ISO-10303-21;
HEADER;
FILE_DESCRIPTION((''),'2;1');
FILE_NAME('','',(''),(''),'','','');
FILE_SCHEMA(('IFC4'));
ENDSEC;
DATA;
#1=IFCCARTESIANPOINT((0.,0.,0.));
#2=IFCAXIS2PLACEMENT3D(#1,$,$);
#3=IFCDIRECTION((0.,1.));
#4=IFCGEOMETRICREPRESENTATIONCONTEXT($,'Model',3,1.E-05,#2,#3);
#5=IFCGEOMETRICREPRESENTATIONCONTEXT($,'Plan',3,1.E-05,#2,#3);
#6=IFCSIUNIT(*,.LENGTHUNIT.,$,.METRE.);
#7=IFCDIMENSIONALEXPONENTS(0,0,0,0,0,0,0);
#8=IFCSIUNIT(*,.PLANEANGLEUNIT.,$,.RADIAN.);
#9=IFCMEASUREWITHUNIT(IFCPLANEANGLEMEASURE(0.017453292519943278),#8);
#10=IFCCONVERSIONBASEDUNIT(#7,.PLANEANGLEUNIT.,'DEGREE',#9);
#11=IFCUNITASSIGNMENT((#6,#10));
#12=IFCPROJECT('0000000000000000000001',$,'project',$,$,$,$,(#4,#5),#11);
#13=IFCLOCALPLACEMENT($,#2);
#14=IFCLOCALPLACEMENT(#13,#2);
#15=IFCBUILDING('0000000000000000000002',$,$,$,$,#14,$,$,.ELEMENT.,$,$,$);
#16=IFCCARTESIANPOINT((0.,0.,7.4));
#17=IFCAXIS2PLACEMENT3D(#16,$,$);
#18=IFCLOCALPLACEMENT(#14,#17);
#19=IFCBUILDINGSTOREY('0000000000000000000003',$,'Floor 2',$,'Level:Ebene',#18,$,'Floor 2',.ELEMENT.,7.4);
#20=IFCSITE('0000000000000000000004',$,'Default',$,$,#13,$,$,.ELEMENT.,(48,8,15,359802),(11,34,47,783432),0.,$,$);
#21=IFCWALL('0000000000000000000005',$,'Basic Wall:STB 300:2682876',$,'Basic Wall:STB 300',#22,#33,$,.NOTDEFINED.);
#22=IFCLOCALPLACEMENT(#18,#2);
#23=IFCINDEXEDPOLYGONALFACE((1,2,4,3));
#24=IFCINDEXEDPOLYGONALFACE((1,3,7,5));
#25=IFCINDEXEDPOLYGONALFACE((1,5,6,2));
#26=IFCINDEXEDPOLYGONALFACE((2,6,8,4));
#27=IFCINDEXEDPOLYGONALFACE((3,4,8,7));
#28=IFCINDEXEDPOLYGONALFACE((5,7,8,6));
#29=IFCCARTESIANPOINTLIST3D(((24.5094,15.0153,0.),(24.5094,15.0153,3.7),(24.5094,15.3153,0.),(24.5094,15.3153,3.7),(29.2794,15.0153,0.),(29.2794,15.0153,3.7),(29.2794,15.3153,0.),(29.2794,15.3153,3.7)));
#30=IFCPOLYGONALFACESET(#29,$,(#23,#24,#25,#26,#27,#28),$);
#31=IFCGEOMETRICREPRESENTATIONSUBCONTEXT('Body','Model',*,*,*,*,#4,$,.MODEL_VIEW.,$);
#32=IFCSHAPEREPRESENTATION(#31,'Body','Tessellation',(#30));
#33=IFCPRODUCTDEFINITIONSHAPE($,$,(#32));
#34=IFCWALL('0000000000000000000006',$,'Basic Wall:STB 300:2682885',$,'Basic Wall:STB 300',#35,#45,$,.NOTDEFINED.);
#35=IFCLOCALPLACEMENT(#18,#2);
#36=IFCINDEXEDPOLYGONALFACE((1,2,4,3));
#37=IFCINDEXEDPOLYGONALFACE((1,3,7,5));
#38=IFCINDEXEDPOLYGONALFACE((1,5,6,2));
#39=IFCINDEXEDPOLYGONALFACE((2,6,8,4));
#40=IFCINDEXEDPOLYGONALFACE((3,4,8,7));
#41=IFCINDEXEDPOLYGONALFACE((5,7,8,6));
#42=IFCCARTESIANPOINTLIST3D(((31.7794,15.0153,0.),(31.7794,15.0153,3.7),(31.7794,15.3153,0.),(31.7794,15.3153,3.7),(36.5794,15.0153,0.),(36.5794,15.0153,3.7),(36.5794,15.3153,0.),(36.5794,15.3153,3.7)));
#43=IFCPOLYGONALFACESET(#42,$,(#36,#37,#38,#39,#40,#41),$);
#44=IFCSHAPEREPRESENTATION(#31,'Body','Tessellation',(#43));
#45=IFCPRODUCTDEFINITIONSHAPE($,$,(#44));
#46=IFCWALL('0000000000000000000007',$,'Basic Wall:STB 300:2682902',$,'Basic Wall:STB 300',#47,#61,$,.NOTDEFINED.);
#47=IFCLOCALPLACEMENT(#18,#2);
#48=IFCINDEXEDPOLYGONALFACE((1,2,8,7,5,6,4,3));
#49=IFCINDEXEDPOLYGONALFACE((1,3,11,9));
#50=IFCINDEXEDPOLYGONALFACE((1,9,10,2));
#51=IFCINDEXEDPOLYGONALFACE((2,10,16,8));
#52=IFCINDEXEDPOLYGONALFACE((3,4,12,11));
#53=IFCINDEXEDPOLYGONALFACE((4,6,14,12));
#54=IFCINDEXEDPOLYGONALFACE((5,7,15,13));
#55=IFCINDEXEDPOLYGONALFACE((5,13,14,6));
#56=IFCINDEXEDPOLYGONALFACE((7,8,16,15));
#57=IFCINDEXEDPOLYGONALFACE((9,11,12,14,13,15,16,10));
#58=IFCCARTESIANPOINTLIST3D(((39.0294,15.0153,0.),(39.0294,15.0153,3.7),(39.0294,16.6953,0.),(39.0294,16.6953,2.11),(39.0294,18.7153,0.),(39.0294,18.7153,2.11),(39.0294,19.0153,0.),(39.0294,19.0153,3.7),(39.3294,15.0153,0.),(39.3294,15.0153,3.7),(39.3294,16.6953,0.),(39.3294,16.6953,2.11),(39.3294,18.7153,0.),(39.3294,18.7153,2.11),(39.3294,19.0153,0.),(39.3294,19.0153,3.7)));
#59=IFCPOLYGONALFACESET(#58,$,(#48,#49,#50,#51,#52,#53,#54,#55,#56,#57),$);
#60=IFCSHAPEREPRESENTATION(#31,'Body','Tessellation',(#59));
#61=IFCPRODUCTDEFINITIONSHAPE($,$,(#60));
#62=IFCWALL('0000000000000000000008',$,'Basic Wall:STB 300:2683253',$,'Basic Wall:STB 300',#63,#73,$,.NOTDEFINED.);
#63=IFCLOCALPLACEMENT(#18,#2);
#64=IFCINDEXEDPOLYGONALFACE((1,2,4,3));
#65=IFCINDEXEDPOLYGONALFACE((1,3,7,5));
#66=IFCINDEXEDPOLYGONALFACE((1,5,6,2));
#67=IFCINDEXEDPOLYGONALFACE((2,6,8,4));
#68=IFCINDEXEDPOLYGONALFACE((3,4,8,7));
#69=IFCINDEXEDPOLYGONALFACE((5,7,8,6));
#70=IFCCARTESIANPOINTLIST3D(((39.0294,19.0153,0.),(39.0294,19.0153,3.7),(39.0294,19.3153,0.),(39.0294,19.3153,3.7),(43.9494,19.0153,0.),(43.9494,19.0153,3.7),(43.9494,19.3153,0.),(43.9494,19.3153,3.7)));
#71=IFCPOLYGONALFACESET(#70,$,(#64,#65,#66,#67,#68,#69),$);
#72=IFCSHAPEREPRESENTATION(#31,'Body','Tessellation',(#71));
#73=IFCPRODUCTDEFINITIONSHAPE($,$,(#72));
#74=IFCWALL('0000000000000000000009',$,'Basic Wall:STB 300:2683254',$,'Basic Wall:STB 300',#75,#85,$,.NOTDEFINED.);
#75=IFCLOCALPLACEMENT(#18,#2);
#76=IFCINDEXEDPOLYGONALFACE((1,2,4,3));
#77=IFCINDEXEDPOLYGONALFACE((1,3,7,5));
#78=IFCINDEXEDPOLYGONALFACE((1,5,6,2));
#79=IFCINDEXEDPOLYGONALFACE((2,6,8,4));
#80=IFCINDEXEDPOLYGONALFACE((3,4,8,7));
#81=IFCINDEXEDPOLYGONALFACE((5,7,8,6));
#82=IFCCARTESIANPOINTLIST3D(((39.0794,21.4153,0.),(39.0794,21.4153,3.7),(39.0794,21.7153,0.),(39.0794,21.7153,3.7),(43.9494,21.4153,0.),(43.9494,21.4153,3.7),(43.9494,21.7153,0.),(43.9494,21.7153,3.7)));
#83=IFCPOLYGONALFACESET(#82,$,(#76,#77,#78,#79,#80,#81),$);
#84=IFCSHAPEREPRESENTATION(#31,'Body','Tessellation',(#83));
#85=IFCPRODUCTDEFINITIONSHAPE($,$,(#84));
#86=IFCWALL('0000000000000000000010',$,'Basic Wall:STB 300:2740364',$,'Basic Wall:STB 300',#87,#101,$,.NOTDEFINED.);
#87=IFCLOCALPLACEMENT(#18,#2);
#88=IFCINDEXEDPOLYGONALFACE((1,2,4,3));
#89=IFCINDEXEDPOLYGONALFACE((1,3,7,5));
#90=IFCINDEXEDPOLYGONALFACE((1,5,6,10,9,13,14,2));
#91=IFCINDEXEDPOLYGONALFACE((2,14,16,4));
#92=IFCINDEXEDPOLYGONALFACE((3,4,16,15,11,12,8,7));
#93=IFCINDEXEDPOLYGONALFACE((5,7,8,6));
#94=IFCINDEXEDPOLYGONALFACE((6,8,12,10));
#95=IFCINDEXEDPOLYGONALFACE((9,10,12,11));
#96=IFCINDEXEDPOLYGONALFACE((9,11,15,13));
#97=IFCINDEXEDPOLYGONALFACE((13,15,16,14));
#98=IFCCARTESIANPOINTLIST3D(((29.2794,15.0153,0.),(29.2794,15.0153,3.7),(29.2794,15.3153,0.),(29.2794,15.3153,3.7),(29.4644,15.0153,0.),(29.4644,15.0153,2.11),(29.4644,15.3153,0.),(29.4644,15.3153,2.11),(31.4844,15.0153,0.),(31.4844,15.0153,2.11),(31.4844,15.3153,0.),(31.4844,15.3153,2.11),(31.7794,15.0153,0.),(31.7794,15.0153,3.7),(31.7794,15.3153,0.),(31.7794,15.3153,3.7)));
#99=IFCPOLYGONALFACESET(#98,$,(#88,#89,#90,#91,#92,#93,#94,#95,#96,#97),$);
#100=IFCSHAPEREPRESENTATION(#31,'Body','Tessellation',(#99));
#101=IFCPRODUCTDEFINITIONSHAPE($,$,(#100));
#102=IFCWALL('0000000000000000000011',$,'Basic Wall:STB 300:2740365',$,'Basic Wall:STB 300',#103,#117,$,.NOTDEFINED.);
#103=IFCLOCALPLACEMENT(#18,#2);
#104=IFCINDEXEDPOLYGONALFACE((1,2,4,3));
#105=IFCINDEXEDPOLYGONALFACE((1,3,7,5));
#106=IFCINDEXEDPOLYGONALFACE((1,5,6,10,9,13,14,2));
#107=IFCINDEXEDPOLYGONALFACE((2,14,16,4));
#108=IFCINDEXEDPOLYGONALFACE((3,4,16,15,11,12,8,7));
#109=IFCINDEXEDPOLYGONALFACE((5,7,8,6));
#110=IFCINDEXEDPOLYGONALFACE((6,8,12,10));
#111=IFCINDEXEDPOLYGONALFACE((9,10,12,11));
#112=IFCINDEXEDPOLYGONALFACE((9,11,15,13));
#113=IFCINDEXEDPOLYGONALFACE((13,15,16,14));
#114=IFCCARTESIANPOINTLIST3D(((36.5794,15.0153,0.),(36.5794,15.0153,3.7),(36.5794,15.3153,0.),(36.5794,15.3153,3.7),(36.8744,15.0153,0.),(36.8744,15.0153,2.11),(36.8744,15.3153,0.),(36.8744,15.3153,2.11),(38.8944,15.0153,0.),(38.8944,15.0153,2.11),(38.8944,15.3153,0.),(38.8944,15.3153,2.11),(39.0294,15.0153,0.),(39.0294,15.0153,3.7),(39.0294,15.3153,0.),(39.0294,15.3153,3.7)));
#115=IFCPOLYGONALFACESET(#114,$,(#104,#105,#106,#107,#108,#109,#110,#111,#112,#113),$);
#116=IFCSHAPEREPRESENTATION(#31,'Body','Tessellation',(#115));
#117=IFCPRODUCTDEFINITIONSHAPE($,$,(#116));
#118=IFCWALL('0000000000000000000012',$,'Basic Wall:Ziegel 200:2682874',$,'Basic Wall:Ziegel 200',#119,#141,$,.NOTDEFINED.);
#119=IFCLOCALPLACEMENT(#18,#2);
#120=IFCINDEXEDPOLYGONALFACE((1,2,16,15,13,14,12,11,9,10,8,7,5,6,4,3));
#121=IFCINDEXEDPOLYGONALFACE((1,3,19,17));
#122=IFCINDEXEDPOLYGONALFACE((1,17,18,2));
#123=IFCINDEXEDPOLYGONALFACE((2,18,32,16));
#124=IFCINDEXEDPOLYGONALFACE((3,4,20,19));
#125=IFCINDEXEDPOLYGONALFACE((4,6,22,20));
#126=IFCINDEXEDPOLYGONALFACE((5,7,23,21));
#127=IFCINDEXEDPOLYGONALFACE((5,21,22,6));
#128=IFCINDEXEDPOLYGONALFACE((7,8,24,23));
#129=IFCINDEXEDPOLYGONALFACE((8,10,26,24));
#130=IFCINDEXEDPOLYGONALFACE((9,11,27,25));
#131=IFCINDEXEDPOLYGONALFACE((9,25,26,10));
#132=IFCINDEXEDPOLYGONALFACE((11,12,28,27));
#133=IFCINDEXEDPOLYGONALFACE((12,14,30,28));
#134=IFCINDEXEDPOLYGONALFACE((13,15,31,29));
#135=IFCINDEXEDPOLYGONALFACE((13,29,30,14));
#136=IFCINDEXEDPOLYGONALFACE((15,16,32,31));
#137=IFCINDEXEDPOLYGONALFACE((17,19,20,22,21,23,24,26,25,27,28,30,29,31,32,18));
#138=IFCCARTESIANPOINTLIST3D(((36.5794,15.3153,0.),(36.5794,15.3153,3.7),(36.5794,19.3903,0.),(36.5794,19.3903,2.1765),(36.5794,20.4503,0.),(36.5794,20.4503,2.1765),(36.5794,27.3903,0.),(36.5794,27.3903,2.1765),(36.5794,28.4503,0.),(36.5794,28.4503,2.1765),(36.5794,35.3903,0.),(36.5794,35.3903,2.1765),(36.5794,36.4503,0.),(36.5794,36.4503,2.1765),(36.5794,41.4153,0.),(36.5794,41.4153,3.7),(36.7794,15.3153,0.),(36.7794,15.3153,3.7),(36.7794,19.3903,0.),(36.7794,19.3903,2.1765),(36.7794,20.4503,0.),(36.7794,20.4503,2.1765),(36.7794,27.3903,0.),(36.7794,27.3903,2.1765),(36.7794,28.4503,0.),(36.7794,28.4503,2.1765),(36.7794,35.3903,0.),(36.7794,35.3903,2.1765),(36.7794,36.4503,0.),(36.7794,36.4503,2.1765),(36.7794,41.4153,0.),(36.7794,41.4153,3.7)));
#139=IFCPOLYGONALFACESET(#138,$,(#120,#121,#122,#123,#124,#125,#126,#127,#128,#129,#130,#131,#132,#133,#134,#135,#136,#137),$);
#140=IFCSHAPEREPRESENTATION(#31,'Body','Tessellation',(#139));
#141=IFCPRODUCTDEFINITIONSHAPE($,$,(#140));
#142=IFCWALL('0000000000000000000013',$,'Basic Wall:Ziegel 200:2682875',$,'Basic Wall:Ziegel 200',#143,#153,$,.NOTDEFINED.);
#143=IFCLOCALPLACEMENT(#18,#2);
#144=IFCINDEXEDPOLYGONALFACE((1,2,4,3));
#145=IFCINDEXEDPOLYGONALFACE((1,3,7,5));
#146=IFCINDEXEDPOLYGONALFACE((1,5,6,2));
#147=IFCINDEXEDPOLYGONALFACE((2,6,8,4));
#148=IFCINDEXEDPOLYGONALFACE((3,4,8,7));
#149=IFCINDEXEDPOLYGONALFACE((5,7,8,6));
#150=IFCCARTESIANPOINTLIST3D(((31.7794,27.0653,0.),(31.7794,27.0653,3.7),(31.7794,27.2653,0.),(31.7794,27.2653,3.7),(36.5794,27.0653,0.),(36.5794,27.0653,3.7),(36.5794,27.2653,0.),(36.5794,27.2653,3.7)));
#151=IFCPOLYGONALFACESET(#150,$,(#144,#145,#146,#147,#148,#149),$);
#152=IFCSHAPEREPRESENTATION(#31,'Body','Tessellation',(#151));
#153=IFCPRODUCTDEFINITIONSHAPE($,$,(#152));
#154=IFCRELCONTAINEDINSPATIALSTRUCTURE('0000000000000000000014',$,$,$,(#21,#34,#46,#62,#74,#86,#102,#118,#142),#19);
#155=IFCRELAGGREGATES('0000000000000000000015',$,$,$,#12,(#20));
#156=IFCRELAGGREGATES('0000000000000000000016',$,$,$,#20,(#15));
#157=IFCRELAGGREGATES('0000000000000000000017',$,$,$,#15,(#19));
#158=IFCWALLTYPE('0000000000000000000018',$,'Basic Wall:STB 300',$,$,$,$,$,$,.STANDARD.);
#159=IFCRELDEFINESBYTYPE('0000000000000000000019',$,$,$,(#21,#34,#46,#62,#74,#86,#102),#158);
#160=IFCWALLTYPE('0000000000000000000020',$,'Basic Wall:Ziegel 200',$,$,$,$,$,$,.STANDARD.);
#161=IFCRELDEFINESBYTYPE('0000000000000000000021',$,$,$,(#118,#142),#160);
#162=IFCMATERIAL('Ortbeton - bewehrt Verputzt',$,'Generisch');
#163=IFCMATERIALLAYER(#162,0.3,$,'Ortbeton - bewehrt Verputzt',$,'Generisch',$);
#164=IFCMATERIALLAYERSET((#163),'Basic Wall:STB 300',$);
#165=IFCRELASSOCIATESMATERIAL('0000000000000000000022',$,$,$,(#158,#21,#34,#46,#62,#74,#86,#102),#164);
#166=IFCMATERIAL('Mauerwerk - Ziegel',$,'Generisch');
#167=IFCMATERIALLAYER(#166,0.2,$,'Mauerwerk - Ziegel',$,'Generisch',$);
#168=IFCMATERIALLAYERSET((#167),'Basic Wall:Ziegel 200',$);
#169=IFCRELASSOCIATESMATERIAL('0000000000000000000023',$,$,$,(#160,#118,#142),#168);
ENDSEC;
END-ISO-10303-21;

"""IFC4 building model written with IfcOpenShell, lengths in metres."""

from ifc_helpers import new_model, entity, si_unit, converted_unit, direction, frame, frame_2d, origin, place, context, subcontext, project, spatial, rectangle, extrude, material, layer, layer_set, layer_usage, type_object, element, save


model = new_model("IFC4")

# Units and contexts
model_context = context("Model", 3, precision=1e-05, world=origin(), true_north=direction((0.0, 1.0)))
plan_context = context("Plan", 3, precision=1e-05, world=origin(), true_north=direction((0.0, 1.0)))
body_context = subcontext(model_context, "Body", "Model", "MODEL_VIEW")
ifc_project = project(units=[si_unit("LENGTHUNIT", "METRE"), converted_unit("PLANEANGLEUNIT", "DEGREE", entity("IfcPlaneAngleMeasure", 0.017453292519943278), si_unit("PLANEANGLEUNIT", "RADIAN"), dimensions=[0, 0, 0, 0, 0, 0, 0])], contexts=[model_context, plan_context])

# Site, building, storey
site_placement = place(None, origin())
site = spatial("IfcSite", under=ifc_project, at=site_placement, Name="Default", CompositionType="ELEMENT", RefLatitude=(48, 8, 15, 359802), RefLongitude=(11, 34, 47, 783432), RefElevation=0.0)
building_placement = place(site_placement, origin())
building = spatial("IfcBuilding", under=site, at=building_placement, CompositionType="ELEMENT")
storey_placement = place(building_placement, frame((0.0, 0.0, 7.4)))
storey = spatial("IfcBuildingStorey", under=building, at=storey_placement, Name="Floor 2", ObjectType="Level:Ebene", LongName="Floor 2", CompositionType="ELEMENT", Elevation=7.4)

# Walls
ifc_material_1 = material(Name="Ortbeton - bewehrt Verputzt", Category="Generisch")
ifc_layer_1 = layer(ifc_material_1, 0.3, Name="Ortbeton - bewehrt Verputzt", Category="Generisch")
ifc_layer_set_1 = layer_set([ifc_layer_1], Name="Basic Wall:STB 300")
ifc_layer_usage_1 = layer_usage(ifc_layer_set_1, "AXIS2", "NEGATIVE", 0.15)
wall_type_1 = type_object("IfcWallType", Name="Basic Wall:STB 300", PredefinedType="STANDARD", material=ifc_layer_set_1)
wall_1_placement = place(storey_placement, frame((24.5094, 15.1653, 0.0)))
element("IfcWall", 1, at=wall_1_placement, inside=storey, type_object=wall_type_1, material=ifc_layer_usage_1, Name="Basic Wall:STB 300:2682876", ObjectType="Basic Wall:STB 300", PredefinedType="NOTDEFINED", context=body_context, shape_type="SweptSolid", body=[
    extrude(rectangle(XDim=4.77, YDim=0.3, at=frame_2d((2.385, 0.0), x_axis=(-1.0, 0.0))), origin(), (0.0, 0.0, 1.0), 3.7),
])
wall_2_placement = place(storey_placement, frame((31.7794, 15.1653, 0.0)))
element("IfcWall", 2, at=wall_2_placement, inside=storey, type_object=wall_type_1, material=ifc_layer_usage_1, Name="Basic Wall:STB 300:2682885", ObjectType="Basic Wall:STB 300", PredefinedType="NOTDEFINED", context=body_context, shape_type="SweptSolid", body=[
    extrude(rectangle(XDim=4.8, YDim=0.3, at=frame_2d((2.4, 0.0), x_axis=(-1.0, 0.0))), origin(), (0.0, 0.0, 1.0), 3.7),
])

# Wall, opening
wall_3_placement = place(storey_placement, frame((39.1794, 19.0153, 0.0), z_axis=(0.0, 0.0, 1.0), x_axis=(0.0, -1.0, 0.0)))
wall_3 = element("IfcWall", 3, at=wall_3_placement, inside=storey, type_object=wall_type_1, material=ifc_layer_usage_1, Name="Basic Wall:STB 300:2682902", ObjectType="Basic Wall:STB 300", PredefinedType="NOTDEFINED", context=body_context, shape_type="SweptSolid", body=[
    extrude(rectangle(XDim=4.0, YDim=0.3, at=frame_2d((2.0, 0.0), x_axis=(1.0, 0.0))), origin(), (0.0, 0.0, 1.0), 3.7),
])
opening_1_placement = place(wall_3_placement, frame((2.32, 0.15, 0.0)))
element("IfcOpeningElement", 4, at=opening_1_placement, cuts=wall_3, PredefinedType="OPENING", context=body_context, shape_type="SweptSolid", body=[
    extrude(rectangle(XDim=2.11, YDim=2.02, at=frame_2d((1.055, 1.01), x_axis=(1.0, 0.0))), frame((0.0, 0.0, 0.0), z_axis=(0.0, -1.0, 0.0), x_axis=(0.0, 0.0, 1.0)), (0.0, 0.0, 1.0), 0.3),
])

# Walls
wall_4_placement = place(storey_placement, frame((43.9494, 19.1653, 0.0), z_axis=(0.0, 0.0, 1.0), x_axis=(-1.0, 0.0, 0.0)))
element("IfcWall", 5, at=wall_4_placement, inside=storey, type_object=wall_type_1, material=ifc_layer_usage_1, Name="Basic Wall:STB 300:2683253", ObjectType="Basic Wall:STB 300", PredefinedType="NOTDEFINED", context=body_context, shape_type="SweptSolid", body=[
    extrude(rectangle(XDim=4.92, YDim=0.3, at=frame_2d((2.46, 0.0), x_axis=(-1.0, 0.0))), origin(), (0.0, 0.0, 1.0), 3.7),
])
wall_5_placement = place(storey_placement, frame((39.0794, 21.5653, 0.0)))
element("IfcWall", 6, at=wall_5_placement, inside=storey, type_object=wall_type_1, material=ifc_layer_usage_1, Name="Basic Wall:STB 300:2683254", ObjectType="Basic Wall:STB 300", PredefinedType="NOTDEFINED", context=body_context, shape_type="SweptSolid", body=[
    extrude(rectangle(XDim=4.87, YDim=0.3, at=frame_2d((2.435, 0.0), x_axis=(-1.0, 0.0))), origin(), (0.0, 0.0, 1.0), 3.7),
])

# Walls, openings
wall_6_placement = place(storey_placement, frame((29.2794, 15.1653, 0.0)))
wall_6 = element("IfcWall", 7, at=wall_6_placement, inside=storey, type_object=wall_type_1, material=ifc_layer_usage_1, Name="Basic Wall:STB 300:2740364", ObjectType="Basic Wall:STB 300", PredefinedType="NOTDEFINED", context=body_context, shape_type="SweptSolid", body=[
    extrude(rectangle(XDim=2.5, YDim=0.3, at=frame_2d((1.25, 0.0), x_axis=(-1.0, 0.0))), origin(), (0.0, 0.0, 1.0), 3.7),
])
opening_2_placement = place(wall_6_placement, frame((0.185, -0.15, 0.0)))
element("IfcOpeningElement", 8, at=opening_2_placement, cuts=wall_6, PredefinedType="OPENING", context=body_context, shape_type="SweptSolid", body=[
    extrude(rectangle(XDim=2.11, YDim=2.02, at=frame_2d((1.055, 1.01), x_axis=(1.0, 0.0))), frame((0.0, 0.0, 0.0), z_axis=(0.0, 1.0, 0.0), x_axis=(0.0, 0.0, 1.0)), (0.0, 0.0, 1.0), 0.3),
])
wall_7_placement = place(storey_placement, frame((36.5794, 15.1653, 0.0)))
wall_7 = element("IfcWall", 9, at=wall_7_placement, inside=storey, type_object=wall_type_1, material=ifc_layer_usage_1, Name="Basic Wall:STB 300:2740365", ObjectType="Basic Wall:STB 300", PredefinedType="NOTDEFINED", context=body_context, shape_type="SweptSolid", body=[
    extrude(rectangle(XDim=2.45, YDim=0.3, at=frame_2d((1.225, 0.0), x_axis=(-1.0, 0.0))), origin(), (0.0, 0.0, 1.0), 3.7),
])
opening_3_placement = place(wall_7_placement, frame((0.295, -0.15, 0.0)))
element("IfcOpeningElement", 10, at=opening_3_placement, cuts=wall_7, PredefinedType="OPENING", context=body_context, shape_type="SweptSolid", body=[
    extrude(rectangle(XDim=2.11, YDim=2.02, at=frame_2d((1.055, 1.01), x_axis=(1.0, 0.0))), frame((0.0, 0.0, 0.0), z_axis=(0.0, 1.0, 0.0), x_axis=(0.0, 0.0, 1.0)), (0.0, 0.0, 1.0), 0.3),
])

# Wall, openings
ifc_material_2 = material(Name="Mauerwerk - Ziegel", Category="Generisch")
ifc_layer_2 = layer(ifc_material_2, 0.2, Name="Mauerwerk - Ziegel", Category="Generisch")
ifc_layer_set_2 = layer_set([ifc_layer_2], Name="Basic Wall:Ziegel 200")
ifc_layer_usage_2 = layer_usage(ifc_layer_set_2, "AXIS2", "NEGATIVE", 0.1)
wall_type_2 = type_object("IfcWallType", Name="Basic Wall:Ziegel 200", PredefinedType="STANDARD", material=ifc_layer_set_2)
wall_8_placement = place(storey_placement, frame((36.6794, 15.3153, 0.0), z_axis=(0.0, 0.0, 1.0), x_axis=(0.0, 1.0, 0.0)))
wall_8 = element("IfcWall", 11, at=wall_8_placement, inside=storey, type_object=wall_type_2, material=ifc_layer_usage_2, Name="Basic Wall:Ziegel 200:2682874", ObjectType="Basic Wall:Ziegel 200", PredefinedType="NOTDEFINED", context=body_context, shape_type="SweptSolid", body=[
    extrude(rectangle(XDim=26.1, YDim=0.2, at=frame_2d((13.05, 0.0), x_axis=(-1.0, 0.0))), origin(), (0.0, 0.0, 1.0), 3.7),
])
opening_4_placement = place(wall_8_placement, frame((21.135, 0.1, 0.0)))
element("IfcOpeningElement", 12, at=opening_4_placement, cuts=wall_8, PredefinedType="OPENING", context=body_context, shape_type="SweptSolid", body=[
    extrude(rectangle(XDim=2.1765, YDim=1.06, at=frame_2d((1.0882, 0.53), x_axis=(1.0, 0.0))), frame((0.0, 0.0, 0.0), z_axis=(0.0, -1.0, 0.0), x_axis=(0.0, 0.0, 1.0)), (0.0, 0.0, 1.0), 0.2),
])
opening_5_placement = place(wall_8_placement, frame((13.135, 0.1, 0.0)))
element("IfcOpeningElement", 13, at=opening_5_placement, cuts=wall_8, PredefinedType="OPENING", context=body_context, shape_type="SweptSolid", body=[
    extrude(rectangle(XDim=2.1765, YDim=1.06, at=frame_2d((1.0882, 0.53), x_axis=(1.0, 0.0))), frame((0.0, 0.0, 0.0), z_axis=(0.0, -1.0, 0.0), x_axis=(0.0, 0.0, 1.0)), (0.0, 0.0, 1.0), 0.2),
])
opening_6_placement = place(wall_8_placement, frame((4.075, -0.1, 0.0)))
element("IfcOpeningElement", 14, at=opening_6_placement, cuts=wall_8, PredefinedType="OPENING", context=body_context, shape_type="SweptSolid", body=[
    extrude(rectangle(XDim=2.1765, YDim=1.06, at=frame_2d((1.0882, 0.53), x_axis=(1.0, 0.0))), frame((0.0, 0.0, 0.0), z_axis=(0.0, 1.0, 0.0), x_axis=(0.0, 0.0, 1.0)), (0.0, 0.0, 1.0), 0.2),
])

# Wall
wall_9_placement = place(storey_placement, frame((31.7794, 27.1653, 0.0)))
element("IfcWall", 15, at=wall_9_placement, inside=storey, type_object=wall_type_2, material=ifc_layer_usage_2, Name="Basic Wall:Ziegel 200:2682875", ObjectType="Basic Wall:Ziegel 200", PredefinedType="NOTDEFINED", context=body_context, shape_type="SweptSolid", body=[
    extrude(rectangle(XDim=4.8, YDim=0.2, at=frame_2d((2.4, 0.0), x_axis=(-1.0, 0.0))), origin(), (0.0, 0.0, 1.0), 3.7),
])

save(model, "model.ifc")
